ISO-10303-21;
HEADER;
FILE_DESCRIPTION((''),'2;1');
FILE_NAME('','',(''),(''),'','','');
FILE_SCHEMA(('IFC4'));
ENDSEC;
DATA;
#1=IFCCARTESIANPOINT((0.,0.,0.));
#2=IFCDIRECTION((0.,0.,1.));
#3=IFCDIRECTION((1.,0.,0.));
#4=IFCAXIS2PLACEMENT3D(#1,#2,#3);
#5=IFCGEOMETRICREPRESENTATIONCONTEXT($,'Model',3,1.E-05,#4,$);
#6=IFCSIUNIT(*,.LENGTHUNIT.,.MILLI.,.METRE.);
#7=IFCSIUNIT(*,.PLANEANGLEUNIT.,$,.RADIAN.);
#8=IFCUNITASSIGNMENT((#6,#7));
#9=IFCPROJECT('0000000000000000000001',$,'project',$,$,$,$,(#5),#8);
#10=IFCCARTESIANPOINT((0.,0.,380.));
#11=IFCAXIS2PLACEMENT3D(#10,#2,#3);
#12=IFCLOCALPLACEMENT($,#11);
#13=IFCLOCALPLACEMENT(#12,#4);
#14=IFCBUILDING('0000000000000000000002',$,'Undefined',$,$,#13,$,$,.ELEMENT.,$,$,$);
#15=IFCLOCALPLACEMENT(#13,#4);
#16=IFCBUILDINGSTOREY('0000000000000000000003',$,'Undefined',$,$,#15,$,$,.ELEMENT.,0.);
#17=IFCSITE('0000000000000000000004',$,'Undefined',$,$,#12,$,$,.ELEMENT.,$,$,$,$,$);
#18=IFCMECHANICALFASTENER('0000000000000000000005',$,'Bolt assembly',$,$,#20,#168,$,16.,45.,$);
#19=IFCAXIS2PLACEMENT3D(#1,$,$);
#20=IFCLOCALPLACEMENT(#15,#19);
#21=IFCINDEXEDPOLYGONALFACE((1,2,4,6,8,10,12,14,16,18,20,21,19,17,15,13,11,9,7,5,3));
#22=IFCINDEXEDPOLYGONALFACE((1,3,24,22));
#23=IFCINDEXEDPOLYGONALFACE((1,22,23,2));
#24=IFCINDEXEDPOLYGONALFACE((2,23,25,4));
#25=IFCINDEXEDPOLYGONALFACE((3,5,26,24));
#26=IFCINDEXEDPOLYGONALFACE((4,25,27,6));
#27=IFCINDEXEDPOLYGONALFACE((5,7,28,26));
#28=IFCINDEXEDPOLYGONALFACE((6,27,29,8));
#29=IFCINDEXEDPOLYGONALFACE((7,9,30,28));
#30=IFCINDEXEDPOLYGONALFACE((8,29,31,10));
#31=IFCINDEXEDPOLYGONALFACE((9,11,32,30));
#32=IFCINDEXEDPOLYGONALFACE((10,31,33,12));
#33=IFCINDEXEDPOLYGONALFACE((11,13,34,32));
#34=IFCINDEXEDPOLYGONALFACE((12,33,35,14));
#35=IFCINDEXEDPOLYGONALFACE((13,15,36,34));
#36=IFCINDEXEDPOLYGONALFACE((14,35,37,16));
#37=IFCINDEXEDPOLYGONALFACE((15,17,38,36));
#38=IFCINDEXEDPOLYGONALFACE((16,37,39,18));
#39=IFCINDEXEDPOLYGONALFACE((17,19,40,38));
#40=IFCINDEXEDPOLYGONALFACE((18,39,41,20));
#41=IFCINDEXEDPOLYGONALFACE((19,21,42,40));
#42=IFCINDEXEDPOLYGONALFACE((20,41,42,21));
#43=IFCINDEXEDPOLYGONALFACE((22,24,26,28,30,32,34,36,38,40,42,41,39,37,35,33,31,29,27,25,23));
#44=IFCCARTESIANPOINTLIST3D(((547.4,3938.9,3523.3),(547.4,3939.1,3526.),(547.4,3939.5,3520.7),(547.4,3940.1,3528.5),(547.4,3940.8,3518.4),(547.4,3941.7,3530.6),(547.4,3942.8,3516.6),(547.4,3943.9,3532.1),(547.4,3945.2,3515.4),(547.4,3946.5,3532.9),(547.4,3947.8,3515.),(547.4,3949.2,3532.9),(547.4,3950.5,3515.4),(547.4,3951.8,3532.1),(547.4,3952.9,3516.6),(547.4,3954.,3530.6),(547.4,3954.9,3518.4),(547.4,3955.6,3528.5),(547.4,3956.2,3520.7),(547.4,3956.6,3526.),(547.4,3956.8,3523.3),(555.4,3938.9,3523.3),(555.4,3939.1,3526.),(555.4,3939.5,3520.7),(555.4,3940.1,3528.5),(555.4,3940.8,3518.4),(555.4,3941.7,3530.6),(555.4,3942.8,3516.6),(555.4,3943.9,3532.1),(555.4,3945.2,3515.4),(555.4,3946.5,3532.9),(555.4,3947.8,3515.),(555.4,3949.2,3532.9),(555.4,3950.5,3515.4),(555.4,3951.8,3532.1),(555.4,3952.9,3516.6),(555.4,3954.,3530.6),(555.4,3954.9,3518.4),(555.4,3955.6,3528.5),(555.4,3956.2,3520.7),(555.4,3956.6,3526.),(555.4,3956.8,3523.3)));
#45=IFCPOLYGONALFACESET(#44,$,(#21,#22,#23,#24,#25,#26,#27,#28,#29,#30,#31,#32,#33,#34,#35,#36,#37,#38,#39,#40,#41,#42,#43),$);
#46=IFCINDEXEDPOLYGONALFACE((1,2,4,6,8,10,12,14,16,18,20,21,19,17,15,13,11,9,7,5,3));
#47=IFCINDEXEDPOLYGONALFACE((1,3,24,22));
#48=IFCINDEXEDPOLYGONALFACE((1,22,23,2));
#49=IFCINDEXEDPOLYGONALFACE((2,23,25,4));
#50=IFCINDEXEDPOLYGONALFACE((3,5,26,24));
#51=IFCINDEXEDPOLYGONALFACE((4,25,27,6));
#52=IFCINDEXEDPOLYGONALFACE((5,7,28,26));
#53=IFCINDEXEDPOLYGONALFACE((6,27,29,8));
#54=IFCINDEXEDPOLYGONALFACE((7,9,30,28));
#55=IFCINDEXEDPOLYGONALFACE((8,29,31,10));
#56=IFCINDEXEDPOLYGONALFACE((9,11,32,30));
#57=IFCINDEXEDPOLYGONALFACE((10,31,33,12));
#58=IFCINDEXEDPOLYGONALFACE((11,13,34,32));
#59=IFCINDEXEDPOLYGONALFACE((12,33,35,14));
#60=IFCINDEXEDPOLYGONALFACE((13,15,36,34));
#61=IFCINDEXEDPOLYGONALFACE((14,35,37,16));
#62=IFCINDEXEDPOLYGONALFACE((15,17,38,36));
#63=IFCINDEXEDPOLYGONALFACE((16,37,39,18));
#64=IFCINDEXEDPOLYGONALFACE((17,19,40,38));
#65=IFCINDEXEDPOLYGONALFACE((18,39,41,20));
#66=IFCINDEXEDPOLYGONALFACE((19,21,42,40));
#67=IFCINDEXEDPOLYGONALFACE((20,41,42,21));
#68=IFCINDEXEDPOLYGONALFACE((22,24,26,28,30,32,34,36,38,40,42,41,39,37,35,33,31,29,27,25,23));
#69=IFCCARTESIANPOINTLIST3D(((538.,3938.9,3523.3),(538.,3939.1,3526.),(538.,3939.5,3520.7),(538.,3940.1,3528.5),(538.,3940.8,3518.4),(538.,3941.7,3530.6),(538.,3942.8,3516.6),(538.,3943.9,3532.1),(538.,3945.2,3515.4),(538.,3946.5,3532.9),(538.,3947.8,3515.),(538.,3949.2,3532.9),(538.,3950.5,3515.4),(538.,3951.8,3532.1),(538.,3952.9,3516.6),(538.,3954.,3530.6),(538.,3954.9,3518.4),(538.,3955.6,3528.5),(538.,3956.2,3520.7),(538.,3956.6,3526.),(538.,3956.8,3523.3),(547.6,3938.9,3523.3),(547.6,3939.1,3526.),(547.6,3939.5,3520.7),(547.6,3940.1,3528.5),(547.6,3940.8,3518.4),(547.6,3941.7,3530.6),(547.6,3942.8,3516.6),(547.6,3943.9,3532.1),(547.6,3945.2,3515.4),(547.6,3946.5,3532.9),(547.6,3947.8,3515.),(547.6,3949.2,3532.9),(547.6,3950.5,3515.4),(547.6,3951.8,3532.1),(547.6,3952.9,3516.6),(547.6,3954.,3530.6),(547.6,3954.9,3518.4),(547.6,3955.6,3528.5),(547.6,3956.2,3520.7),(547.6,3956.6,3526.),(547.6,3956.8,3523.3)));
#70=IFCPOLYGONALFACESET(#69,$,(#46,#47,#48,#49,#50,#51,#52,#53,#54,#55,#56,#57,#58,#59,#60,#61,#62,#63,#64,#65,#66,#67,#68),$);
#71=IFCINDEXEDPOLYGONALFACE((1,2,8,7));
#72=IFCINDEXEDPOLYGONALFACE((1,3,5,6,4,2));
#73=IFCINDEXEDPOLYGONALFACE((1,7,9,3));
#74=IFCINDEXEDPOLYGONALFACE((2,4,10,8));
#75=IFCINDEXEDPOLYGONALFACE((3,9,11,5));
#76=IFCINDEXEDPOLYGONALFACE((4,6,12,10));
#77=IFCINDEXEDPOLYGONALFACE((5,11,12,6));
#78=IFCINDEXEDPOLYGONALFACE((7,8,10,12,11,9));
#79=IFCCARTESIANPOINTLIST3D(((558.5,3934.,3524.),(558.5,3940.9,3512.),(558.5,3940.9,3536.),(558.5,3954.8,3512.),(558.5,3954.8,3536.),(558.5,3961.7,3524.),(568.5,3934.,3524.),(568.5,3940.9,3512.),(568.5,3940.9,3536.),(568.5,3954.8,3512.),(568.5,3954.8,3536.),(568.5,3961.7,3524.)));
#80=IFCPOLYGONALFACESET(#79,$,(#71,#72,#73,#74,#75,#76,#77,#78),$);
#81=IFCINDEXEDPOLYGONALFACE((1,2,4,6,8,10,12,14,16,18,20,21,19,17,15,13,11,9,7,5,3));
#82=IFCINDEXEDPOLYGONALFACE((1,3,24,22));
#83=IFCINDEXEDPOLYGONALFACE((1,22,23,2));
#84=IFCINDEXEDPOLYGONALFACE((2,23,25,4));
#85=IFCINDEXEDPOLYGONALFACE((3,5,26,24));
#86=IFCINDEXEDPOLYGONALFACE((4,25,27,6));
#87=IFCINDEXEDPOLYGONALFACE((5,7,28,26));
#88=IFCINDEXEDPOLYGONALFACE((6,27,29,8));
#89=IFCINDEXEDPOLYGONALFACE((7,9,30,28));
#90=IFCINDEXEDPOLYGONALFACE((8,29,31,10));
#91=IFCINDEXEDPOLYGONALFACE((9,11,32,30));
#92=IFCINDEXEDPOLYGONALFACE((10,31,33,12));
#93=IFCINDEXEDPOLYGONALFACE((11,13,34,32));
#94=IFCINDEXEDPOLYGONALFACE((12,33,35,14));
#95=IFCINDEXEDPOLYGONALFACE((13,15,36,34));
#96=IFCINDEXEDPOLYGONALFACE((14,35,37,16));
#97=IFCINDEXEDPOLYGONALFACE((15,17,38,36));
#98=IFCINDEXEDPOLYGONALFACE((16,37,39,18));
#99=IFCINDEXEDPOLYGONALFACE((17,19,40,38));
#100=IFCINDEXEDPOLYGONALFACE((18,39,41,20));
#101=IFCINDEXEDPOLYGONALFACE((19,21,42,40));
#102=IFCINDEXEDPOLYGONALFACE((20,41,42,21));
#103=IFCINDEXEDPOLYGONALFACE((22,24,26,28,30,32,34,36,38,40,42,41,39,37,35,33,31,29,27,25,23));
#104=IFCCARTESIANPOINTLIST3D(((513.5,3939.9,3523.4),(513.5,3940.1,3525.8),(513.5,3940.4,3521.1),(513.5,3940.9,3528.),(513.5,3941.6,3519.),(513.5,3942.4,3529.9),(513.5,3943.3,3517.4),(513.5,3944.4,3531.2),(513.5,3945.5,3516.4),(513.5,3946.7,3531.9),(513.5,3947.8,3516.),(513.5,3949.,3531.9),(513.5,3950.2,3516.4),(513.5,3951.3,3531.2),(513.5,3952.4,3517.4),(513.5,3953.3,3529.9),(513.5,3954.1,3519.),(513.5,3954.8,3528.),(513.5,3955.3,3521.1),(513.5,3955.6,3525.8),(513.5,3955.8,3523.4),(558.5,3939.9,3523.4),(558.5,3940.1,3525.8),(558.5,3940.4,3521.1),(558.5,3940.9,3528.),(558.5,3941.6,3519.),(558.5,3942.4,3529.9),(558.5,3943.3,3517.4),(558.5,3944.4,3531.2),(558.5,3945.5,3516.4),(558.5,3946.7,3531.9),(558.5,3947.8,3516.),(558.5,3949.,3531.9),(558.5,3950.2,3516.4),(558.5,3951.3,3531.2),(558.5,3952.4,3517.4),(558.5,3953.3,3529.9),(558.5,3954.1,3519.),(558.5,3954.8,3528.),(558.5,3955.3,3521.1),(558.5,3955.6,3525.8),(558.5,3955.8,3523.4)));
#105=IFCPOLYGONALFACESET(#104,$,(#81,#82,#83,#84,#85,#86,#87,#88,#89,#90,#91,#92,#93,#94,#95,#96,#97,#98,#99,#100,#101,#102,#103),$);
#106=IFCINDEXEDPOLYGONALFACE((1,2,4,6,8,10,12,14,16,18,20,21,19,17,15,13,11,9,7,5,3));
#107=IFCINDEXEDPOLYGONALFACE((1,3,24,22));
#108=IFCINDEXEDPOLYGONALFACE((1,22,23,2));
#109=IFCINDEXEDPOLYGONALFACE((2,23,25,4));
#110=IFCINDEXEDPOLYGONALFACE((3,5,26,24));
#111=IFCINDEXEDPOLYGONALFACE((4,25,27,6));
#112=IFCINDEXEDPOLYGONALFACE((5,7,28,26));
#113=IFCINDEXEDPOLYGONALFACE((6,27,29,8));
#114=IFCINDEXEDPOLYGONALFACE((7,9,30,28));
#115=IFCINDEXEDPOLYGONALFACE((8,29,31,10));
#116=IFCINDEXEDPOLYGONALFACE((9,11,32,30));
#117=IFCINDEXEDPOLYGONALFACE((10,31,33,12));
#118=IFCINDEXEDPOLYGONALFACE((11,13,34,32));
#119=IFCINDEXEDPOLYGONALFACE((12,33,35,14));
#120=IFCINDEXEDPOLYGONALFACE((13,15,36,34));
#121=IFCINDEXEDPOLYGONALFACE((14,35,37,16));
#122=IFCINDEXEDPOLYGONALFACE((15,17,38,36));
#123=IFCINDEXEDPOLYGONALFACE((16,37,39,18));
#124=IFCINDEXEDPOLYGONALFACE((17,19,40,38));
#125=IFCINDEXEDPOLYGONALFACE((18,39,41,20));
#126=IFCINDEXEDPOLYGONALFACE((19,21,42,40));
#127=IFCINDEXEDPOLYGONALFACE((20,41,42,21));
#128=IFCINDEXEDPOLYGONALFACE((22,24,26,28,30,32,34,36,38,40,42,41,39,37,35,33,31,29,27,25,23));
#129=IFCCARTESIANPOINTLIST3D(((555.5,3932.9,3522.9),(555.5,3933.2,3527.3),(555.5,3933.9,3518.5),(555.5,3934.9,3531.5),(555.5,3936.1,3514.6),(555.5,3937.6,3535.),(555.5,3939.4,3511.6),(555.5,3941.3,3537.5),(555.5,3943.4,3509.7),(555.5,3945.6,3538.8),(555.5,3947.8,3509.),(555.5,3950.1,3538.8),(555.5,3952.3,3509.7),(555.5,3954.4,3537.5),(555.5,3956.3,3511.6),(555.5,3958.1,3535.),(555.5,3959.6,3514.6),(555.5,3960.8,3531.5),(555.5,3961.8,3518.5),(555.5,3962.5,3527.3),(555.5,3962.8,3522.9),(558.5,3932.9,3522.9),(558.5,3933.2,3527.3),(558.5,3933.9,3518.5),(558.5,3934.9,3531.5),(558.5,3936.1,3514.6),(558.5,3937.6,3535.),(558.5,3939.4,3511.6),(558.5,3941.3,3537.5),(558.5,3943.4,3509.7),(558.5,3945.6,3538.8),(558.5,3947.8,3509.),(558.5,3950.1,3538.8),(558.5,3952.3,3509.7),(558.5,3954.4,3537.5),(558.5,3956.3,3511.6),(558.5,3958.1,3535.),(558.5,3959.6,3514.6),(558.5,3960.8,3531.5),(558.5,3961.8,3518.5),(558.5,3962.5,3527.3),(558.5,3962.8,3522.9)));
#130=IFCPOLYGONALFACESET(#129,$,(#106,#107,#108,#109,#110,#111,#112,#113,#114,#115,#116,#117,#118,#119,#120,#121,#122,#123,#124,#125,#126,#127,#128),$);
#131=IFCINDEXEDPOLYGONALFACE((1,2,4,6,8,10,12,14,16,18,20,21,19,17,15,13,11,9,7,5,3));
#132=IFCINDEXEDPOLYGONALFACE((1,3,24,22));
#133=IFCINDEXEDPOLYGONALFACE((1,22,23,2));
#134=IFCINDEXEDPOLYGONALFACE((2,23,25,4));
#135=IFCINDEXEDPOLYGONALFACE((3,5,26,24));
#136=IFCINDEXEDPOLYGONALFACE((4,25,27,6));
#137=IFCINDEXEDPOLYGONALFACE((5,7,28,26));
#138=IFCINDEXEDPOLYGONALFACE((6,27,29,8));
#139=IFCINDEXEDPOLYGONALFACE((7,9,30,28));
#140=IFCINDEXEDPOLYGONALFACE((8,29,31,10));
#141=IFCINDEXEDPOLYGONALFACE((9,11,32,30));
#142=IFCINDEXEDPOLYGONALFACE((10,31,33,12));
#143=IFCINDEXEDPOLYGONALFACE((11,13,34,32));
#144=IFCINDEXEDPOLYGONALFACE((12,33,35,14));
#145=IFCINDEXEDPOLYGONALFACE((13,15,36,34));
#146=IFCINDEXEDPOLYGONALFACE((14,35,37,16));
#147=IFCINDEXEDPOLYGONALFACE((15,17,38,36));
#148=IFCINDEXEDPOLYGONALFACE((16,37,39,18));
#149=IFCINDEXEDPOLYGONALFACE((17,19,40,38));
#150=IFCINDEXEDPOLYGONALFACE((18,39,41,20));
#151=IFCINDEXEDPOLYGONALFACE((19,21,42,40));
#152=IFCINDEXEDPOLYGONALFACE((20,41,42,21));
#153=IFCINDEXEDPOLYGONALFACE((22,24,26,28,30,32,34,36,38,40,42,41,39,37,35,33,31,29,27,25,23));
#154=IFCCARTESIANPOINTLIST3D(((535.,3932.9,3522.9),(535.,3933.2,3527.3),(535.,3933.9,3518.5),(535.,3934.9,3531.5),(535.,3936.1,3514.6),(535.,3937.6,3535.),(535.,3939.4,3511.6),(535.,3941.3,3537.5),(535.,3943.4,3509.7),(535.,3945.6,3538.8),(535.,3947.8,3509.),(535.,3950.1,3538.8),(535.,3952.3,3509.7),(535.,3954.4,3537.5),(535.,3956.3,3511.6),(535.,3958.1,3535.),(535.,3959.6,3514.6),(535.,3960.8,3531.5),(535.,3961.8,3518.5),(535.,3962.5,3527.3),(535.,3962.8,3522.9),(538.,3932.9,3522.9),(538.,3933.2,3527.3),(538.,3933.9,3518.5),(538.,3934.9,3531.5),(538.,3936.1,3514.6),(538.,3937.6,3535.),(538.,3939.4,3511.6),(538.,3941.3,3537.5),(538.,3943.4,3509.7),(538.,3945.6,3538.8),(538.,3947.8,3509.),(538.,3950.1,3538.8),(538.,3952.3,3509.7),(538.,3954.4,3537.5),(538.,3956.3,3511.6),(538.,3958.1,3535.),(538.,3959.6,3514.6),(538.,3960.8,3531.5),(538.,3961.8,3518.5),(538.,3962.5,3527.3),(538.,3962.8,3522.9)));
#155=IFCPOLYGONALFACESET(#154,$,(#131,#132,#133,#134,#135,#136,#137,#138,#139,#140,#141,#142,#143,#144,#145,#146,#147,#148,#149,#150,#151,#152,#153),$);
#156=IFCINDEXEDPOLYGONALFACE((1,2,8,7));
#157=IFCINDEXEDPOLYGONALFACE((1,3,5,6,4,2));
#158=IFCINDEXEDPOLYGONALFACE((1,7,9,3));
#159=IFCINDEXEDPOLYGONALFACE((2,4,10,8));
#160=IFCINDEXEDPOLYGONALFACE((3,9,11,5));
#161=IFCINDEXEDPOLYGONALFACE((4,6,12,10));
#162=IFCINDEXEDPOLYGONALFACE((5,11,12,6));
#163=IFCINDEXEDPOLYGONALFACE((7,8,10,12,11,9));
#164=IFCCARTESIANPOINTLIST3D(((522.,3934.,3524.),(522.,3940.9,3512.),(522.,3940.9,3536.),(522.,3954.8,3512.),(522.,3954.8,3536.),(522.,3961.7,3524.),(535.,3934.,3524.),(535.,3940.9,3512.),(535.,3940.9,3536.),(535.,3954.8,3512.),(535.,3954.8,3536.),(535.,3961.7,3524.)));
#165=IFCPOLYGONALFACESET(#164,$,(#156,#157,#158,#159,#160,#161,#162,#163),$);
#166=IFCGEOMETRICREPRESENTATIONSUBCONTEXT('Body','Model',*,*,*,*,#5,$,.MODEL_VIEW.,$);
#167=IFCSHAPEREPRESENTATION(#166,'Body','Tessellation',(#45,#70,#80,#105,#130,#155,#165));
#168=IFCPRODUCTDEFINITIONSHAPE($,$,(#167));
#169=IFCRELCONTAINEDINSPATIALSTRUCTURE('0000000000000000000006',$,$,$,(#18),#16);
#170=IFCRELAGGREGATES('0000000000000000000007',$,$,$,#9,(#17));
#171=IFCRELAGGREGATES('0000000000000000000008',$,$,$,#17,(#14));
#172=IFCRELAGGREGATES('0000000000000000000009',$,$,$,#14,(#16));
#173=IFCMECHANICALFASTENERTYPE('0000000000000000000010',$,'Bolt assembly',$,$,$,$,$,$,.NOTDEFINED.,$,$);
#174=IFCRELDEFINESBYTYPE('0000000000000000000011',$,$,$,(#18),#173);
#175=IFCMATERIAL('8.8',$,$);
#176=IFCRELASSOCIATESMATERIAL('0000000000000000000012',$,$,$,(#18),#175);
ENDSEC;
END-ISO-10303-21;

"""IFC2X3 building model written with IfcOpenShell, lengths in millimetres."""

from ifc_helpers import new_model, si_unit, frame, origin_with_axes, origin_2d_with_axis, place, context, subcontext, project, spatial, polyline, circle, outline, extrude, source, transform, mapped, material, type_object, element, save


model = new_model("IFC2X3")

# Units and contexts
model_context = context("Model", 3, precision=1e-05, world=origin_with_axes())
body_context = subcontext(model_context, "Body", "Model", "MODEL_VIEW")
ifc_project = project(units=[si_unit("LENGTHUNIT", "METRE", prefix="MILLI"), si_unit("PLANEANGLEUNIT", "RADIAN")], contexts=[model_context])

# Site, building, storey
site_placement = place(None, frame((0.0, 0.0, 380.0), z_axis=(0.0, 0.0, 1.0), x_axis=(1.0, 0.0, 0.0)))
site = spatial("IfcSite", under=ifc_project, at=site_placement, Name="Undefined", CompositionType="ELEMENT")
building_placement = place(site_placement, origin_with_axes())
building = spatial("IfcBuilding", under=site, at=building_placement, Name="Undefined", CompositionType="ELEMENT")
storey_placement = place(building_placement, origin_with_axes())
storey = spatial("IfcBuildingStorey", under=building, at=storey_placement, Name="Undefined", CompositionType="ELEMENT", Elevation=0.0)

# Mechanical fastener
ifc_material_1 = material(Name="8.8")
mechanical_fastener_type = type_object("IfcMechanicalFastenerType", Name="Bolt assembly")
shared_shape_1 = source(origin_with_axes(), body_context, "Body", "SweptSolid", [
    extrude(circle(Radius=9.0, at=origin_2d_with_axis()), frame((0.0, -7.9, 0.0), z_axis=(0.0, 1.0, 0.0), x_axis=(1.0, 0.0, 0.0)), (0.0, 0.0, 1.0), 8.0),
    extrude(circle(Radius=9.0, at=origin_2d_with_axis()), frame((0.0, -0.1, 0.0), z_axis=(0.0, 1.0, 0.0), x_axis=(1.0, 0.0, 0.0)), (0.0, 0.0, 1.0), 9.6),
    extrude(outline(polyline([(12.0, -6.9), (12.0, 6.9), (0.0, 13.9), (-12.0, 6.9), (-12.0, -6.9), (0.0, -13.9), (12.0, -6.9)])), frame((0.0, -21.0, 0.0), z_axis=(0.0, 1.0, 0.0), x_axis=(1.0, 0.0, 0.0)), (0.0, 0.0, 1.0), 10.0),
    extrude(circle(Radius=8.0, at=origin_2d_with_axis()), frame((0.0, -11.0, 0.0), z_axis=(0.0, 1.0, 0.0), x_axis=(1.0, 0.0, 0.0)), (0.0, 0.0, 1.0), 45.0),
    extrude(circle(Radius=15.0, at=origin_2d_with_axis()), frame((0.0, -11.0, 0.0), z_axis=(0.0, 1.0, 0.0), x_axis=(1.0, 0.0, 0.0)), (0.0, 0.0, 1.0), 3.0),
    extrude(circle(Radius=15.0, at=origin_2d_with_axis()), frame((0.0, 9.5, 0.0), z_axis=(0.0, 1.0, 0.0), x_axis=(1.0, 0.0, 0.0)), (0.0, 0.0, 1.0), 3.0),
    extrude(outline(polyline([(12.0, -6.9), (12.0, 6.9), (0.0, 13.9), (-12.0, 6.9), (-12.0, -6.9), (0.0, -13.9), (12.0, -6.9)])), frame((0.0, 12.5, 0.0), z_axis=(0.0, 1.0, 0.0), x_axis=(1.0, 0.0, 0.0)), (0.0, 0.0, 1.0), 13.0),
])
for number, where, z_axis, x_axis, name in (
    (1, (547.5, 3910.3, 3594.0), (0.0, 1.0, 0.0), (0.0, 0.0, -1.0), "Bolt assembly"),
):
    element("IfcMechanicalFastener", number, at=place(storey_placement, frame(where, z_axis=z_axis, x_axis=x_axis)), inside=storey, type_object=mechanical_fastener_type, material=ifc_material_1, Name=name, NominalDiameter=16.0, NominalLength=45.0, context=body_context, shape_type="MappedRepresentation", body=[
        mapped(shared_shape_1, transform((70.0, 0.0, 37.5))),
    ])

save(model, "model.ifc")
